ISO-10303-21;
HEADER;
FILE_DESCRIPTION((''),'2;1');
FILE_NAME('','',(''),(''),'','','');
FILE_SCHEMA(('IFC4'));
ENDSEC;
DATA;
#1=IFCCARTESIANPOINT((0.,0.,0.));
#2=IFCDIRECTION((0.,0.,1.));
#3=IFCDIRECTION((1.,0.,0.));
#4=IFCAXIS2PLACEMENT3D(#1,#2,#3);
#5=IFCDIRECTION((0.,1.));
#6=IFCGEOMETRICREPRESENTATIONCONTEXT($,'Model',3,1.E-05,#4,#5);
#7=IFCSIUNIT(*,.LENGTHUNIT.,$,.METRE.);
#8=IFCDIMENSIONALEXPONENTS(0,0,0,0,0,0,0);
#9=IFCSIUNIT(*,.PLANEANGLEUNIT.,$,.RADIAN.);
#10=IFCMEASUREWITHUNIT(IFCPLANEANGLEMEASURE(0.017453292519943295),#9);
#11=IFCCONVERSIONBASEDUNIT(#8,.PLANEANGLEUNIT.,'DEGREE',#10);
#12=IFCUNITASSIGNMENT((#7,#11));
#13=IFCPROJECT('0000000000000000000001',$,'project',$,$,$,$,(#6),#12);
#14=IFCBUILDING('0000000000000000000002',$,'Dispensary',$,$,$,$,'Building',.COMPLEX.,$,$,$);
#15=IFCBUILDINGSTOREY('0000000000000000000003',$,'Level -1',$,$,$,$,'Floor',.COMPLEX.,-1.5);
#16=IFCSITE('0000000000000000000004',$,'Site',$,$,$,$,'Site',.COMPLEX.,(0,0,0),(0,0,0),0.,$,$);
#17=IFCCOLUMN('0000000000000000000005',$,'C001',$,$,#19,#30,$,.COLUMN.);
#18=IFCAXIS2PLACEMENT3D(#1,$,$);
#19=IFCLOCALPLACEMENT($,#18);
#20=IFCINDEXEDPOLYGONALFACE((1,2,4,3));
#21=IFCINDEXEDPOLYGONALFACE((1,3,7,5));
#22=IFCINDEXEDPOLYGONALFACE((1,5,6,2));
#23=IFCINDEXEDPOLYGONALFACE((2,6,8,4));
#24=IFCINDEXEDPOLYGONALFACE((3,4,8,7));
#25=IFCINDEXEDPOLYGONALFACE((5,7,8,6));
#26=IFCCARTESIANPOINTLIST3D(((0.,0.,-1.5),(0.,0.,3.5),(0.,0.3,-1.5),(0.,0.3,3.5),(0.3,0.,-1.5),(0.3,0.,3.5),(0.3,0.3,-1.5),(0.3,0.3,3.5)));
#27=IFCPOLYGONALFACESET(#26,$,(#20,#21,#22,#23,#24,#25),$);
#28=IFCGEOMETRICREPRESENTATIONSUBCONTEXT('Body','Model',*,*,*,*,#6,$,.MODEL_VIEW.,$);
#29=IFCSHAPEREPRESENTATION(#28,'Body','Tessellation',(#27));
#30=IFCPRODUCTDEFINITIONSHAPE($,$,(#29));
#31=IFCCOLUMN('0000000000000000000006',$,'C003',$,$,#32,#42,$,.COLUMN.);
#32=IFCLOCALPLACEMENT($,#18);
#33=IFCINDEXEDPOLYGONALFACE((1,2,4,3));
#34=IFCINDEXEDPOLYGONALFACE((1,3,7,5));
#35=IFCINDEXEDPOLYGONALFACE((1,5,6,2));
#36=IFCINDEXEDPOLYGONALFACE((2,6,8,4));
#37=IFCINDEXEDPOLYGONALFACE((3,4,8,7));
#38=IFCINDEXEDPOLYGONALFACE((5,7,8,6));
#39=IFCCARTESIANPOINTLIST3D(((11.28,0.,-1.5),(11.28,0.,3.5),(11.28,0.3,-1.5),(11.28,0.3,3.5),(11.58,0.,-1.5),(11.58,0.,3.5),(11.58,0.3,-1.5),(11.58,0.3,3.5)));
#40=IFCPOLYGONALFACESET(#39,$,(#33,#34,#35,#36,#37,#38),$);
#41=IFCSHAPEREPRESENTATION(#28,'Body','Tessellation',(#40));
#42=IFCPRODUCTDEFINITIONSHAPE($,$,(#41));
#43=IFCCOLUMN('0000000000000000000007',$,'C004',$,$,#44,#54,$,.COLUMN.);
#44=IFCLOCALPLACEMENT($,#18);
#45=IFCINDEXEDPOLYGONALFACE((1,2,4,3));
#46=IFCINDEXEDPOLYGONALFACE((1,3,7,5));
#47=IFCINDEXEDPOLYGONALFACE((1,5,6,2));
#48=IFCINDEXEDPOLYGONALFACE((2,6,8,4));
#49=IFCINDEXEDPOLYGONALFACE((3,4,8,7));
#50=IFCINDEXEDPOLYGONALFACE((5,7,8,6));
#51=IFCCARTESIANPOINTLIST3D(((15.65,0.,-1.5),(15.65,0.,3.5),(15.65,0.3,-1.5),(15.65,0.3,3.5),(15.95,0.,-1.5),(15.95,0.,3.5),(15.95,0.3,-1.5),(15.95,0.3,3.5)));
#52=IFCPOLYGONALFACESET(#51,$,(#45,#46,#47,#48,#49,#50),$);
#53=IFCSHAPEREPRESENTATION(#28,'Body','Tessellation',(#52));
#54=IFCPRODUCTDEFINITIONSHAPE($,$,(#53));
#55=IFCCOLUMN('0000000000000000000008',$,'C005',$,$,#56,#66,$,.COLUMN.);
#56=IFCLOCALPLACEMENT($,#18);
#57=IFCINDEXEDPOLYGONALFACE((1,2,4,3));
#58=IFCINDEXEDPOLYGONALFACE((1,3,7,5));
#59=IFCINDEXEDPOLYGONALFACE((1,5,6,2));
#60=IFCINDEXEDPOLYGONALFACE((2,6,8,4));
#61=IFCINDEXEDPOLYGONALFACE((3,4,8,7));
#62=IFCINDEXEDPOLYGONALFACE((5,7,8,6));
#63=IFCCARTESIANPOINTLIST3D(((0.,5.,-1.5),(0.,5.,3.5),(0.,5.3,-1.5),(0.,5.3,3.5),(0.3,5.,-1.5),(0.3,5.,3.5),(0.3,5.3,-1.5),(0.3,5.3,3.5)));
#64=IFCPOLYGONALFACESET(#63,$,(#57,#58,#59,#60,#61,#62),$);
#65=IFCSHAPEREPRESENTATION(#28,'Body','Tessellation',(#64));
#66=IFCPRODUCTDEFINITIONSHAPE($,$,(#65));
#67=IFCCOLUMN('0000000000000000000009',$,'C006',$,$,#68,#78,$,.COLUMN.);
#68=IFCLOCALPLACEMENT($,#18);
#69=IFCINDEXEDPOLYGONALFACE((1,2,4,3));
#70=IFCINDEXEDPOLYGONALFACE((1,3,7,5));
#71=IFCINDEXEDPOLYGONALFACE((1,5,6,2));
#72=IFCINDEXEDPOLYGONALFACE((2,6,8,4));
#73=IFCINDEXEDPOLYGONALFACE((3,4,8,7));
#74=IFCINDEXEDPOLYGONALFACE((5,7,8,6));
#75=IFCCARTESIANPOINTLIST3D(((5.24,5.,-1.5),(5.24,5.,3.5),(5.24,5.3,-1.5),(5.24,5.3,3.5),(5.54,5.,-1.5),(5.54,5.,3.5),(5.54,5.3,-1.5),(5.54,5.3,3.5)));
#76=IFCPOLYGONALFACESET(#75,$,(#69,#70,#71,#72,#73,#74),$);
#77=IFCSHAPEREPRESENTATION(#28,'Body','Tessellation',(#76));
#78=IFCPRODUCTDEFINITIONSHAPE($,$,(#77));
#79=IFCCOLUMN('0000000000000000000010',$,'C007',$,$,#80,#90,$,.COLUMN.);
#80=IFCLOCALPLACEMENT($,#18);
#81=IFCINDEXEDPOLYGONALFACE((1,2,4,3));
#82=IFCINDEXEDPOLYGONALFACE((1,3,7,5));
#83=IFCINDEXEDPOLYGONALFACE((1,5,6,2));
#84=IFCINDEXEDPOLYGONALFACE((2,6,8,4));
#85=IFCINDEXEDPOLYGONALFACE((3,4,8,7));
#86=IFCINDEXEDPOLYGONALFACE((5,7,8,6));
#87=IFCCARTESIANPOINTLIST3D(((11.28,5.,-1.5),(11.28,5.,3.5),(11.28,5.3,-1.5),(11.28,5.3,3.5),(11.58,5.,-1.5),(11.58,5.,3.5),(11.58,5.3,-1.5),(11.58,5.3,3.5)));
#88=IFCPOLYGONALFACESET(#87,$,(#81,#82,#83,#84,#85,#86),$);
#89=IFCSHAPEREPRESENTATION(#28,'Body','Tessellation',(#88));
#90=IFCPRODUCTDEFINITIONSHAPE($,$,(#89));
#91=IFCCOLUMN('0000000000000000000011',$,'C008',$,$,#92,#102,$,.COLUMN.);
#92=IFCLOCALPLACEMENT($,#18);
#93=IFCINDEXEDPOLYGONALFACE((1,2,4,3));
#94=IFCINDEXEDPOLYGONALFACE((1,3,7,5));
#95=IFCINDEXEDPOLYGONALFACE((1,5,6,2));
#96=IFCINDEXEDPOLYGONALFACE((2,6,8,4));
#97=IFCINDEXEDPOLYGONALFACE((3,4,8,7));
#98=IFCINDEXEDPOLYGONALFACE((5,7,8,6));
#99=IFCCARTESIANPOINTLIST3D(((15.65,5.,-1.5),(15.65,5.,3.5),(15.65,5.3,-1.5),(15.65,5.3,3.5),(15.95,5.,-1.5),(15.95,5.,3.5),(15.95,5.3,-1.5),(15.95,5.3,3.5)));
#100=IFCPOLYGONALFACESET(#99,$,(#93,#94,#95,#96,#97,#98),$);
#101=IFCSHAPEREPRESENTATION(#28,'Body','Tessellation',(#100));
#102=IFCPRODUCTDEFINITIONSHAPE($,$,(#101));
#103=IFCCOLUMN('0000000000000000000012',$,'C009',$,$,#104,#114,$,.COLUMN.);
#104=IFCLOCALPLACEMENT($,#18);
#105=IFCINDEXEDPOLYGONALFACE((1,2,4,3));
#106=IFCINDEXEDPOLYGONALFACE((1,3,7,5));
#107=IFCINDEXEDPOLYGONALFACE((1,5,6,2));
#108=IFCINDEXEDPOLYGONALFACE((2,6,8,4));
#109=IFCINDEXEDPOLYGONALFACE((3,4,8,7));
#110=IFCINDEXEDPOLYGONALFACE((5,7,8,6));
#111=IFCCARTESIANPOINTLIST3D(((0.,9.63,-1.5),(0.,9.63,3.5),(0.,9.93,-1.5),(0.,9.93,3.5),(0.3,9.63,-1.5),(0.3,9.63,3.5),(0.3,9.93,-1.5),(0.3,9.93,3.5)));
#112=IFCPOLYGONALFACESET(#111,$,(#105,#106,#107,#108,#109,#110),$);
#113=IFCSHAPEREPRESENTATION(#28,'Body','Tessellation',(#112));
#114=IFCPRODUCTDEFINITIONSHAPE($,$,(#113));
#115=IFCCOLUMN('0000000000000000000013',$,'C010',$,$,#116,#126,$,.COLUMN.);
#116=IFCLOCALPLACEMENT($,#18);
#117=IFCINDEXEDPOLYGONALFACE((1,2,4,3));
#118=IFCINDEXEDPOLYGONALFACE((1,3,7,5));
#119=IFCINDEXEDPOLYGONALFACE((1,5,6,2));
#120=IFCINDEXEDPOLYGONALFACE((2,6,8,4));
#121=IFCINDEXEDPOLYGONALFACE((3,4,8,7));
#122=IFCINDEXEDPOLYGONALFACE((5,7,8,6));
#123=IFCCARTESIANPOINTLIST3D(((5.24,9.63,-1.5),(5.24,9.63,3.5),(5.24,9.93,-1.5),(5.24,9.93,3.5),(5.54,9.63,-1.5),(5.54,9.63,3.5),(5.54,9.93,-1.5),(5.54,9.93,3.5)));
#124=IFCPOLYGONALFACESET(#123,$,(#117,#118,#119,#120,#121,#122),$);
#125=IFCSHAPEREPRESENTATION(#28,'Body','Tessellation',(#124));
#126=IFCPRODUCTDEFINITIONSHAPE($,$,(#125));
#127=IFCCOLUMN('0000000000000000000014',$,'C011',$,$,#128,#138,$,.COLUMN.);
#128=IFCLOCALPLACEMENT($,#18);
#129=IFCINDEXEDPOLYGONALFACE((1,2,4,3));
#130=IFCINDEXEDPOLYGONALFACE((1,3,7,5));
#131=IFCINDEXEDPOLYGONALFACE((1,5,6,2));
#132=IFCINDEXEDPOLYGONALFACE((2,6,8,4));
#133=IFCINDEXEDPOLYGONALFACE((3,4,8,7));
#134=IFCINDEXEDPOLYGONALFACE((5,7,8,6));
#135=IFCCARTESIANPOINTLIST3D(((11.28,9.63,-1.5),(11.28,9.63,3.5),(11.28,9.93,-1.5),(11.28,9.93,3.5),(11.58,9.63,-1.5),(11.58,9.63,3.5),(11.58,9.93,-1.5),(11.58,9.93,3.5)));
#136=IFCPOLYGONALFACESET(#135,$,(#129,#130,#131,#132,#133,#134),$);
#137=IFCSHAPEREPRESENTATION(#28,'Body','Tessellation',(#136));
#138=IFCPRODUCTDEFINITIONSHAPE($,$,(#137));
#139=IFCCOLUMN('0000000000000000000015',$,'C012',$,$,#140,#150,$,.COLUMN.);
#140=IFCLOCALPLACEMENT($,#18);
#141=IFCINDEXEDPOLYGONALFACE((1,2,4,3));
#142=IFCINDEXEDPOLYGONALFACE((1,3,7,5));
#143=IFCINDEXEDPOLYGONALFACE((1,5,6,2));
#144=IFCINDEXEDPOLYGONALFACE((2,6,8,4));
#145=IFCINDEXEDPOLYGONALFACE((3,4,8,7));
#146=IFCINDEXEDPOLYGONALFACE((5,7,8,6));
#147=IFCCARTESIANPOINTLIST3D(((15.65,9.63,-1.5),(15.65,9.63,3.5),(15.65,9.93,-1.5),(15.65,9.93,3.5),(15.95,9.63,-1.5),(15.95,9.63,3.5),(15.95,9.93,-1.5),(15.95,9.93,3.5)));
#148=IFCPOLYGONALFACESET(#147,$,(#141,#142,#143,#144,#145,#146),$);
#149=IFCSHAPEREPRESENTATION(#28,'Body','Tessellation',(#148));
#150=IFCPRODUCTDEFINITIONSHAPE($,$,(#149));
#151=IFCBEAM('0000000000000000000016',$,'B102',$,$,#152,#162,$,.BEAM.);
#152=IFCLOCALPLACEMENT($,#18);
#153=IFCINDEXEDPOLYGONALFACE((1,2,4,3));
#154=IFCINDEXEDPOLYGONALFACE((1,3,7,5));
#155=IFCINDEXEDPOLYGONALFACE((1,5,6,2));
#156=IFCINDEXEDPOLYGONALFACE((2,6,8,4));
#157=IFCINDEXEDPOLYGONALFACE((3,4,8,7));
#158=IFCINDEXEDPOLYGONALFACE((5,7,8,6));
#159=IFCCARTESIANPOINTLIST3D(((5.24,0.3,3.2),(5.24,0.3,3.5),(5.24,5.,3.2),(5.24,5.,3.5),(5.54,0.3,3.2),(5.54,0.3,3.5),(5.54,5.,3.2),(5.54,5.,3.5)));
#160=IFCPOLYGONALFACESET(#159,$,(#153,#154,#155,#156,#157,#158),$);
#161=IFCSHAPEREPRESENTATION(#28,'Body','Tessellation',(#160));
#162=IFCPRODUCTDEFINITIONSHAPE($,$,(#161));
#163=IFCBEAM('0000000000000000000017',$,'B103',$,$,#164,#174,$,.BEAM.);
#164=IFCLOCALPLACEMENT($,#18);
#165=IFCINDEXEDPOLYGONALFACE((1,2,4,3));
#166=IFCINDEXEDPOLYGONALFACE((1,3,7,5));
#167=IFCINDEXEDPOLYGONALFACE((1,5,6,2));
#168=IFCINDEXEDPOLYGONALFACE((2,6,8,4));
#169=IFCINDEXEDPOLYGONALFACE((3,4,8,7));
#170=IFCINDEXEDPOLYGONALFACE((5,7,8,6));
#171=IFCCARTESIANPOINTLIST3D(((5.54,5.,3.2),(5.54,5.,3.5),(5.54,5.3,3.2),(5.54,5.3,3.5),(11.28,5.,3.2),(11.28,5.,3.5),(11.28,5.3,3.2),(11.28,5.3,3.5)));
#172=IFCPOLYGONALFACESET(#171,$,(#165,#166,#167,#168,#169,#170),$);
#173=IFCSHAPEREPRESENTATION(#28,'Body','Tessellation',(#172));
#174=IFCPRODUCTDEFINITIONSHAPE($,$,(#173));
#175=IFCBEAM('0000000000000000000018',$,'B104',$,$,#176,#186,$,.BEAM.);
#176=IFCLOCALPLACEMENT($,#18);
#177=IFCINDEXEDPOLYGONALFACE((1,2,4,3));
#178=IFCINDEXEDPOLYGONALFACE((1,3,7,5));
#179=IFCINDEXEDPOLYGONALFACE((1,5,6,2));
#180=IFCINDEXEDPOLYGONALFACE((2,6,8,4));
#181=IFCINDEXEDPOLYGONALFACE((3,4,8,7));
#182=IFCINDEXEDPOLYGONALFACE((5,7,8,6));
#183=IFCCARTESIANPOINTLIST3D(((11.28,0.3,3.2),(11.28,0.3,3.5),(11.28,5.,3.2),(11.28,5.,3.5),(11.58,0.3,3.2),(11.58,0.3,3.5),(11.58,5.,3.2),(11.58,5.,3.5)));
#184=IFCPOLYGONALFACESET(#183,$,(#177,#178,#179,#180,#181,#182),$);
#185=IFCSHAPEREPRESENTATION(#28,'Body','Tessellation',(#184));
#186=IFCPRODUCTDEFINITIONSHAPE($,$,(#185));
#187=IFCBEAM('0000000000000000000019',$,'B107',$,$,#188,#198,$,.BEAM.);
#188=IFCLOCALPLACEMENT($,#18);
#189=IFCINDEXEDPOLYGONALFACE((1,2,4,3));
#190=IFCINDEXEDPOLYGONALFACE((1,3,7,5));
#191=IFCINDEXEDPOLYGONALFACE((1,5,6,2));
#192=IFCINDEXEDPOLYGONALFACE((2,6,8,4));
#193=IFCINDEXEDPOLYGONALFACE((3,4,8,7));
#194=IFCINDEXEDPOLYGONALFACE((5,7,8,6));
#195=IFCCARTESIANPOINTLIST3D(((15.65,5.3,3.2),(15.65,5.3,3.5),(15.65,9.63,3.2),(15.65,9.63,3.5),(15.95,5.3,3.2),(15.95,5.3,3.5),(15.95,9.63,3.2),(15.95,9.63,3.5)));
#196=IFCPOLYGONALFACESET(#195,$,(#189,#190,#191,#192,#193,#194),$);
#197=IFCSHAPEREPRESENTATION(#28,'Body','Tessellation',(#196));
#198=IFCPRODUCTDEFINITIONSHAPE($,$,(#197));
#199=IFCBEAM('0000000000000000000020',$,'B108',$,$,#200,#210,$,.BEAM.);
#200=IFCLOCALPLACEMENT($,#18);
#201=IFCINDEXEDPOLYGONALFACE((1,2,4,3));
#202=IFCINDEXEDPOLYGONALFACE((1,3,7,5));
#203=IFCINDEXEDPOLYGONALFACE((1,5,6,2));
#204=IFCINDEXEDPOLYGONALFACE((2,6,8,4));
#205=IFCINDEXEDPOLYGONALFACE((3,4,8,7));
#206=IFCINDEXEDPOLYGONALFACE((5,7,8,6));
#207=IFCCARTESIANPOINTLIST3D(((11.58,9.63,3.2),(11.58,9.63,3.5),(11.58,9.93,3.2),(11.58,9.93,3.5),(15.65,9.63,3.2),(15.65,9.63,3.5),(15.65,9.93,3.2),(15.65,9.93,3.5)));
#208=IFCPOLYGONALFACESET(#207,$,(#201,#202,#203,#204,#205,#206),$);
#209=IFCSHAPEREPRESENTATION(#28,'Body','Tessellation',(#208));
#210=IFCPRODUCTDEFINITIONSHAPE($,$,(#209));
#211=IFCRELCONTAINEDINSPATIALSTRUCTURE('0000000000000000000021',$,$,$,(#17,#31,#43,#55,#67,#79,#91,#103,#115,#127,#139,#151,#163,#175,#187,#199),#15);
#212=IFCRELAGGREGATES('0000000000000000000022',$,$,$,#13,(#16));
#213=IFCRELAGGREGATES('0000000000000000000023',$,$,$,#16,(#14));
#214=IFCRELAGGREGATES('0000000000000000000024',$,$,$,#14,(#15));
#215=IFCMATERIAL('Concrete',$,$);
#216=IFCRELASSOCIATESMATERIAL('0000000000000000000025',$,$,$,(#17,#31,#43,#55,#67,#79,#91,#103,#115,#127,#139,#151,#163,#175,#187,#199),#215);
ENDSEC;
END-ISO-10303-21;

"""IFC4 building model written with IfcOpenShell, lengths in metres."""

from ifc_helpers import new_model, entity, si_unit, converted_unit, direction, frame, frame_2d, origin_with_axes, place, context, subcontext, project, spatial, rectangle, extrude, material, element, save


model = new_model("IFC4")

# Units and contexts
model_context = context("Model", 3, precision=1e-05, world=origin_with_axes(), true_north=direction((0.0, 1.0)))
body_context = subcontext(model_context, "Body", "Model", "MODEL_VIEW")
ifc_project = project(units=[si_unit("LENGTHUNIT", "METRE"), converted_unit("PLANEANGLEUNIT", "DEGREE", entity("IfcPlaneAngleMeasure", 0.017453292519943295), si_unit("PLANEANGLEUNIT", "RADIAN"), dimensions=[0, 0, 0, 0, 0, 0, 0])], contexts=[model_context])

# Site, building, storey
site = spatial("IfcSite", under=ifc_project, Name="Site", LongName="Site", CompositionType="COMPLEX", RefLatitude=(0, 0, 0), RefLongitude=(0, 0, 0), RefElevation=0.0)
building = spatial("IfcBuilding", under=site, Name="Dispensary", LongName="Building", CompositionType="COMPLEX")
storey = spatial("IfcBuildingStorey", under=building, Name="Level -1", LongName="Floor", CompositionType="COMPLEX", Elevation=-1.5)

# Columns
ifc_material = material(Name="Concrete")
placement = place(None, origin_with_axes())
element("IfcColumn", 1, at=placement, inside=storey, material=ifc_material, Name="C001", PredefinedType="COLUMN", context=body_context, shape_type="SweptSolid", body=[
    extrude(rectangle(XDim=0.3, YDim=0.3, at=frame_2d((0.0, 0.0), x_axis=(1.0, 0.0))), frame((0.15, 0.15, -1.5), z_axis=(0.0, 0.0, 1.0), x_axis=(1.0, 0.0, 0.0)), (0.0, 0.0, 1.0), 5.0),
])
element("IfcColumn", 2, at=placement, inside=storey, material=ifc_material, Name="C003", PredefinedType="COLUMN", context=body_context, shape_type="SweptSolid", body=[
    extrude(rectangle(XDim=0.3, YDim=0.3, at=frame_2d((0.0, 0.0), x_axis=(1.0, 0.0))), frame((11.43, 0.15, -1.5), z_axis=(0.0, 0.0, 1.0), x_axis=(1.0, 0.0, 0.0)), (0.0, 0.0, 1.0), 5.0),
])
element("IfcColumn", 3, at=placement, inside=storey, material=ifc_material, Name="C004", PredefinedType="COLUMN", context=body_context, shape_type="SweptSolid", body=[
    extrude(rectangle(XDim=0.3, YDim=0.3, at=frame_2d((0.0, 0.0), x_axis=(1.0, 0.0))), frame((15.8, 0.15, -1.5), z_axis=(0.0, 0.0, 1.0), x_axis=(1.0, 0.0, 0.0)), (0.0, 0.0, 1.0), 5.0),
])
element("IfcColumn", 4, at=placement, inside=storey, material=ifc_material, Name="C005", PredefinedType="COLUMN", context=body_context, shape_type="SweptSolid", body=[
    extrude(rectangle(XDim=0.3, YDim=0.3, at=frame_2d((0.0, 0.0), x_axis=(1.0, 0.0))), frame((0.15, 5.15, -1.5), z_axis=(0.0, 0.0, 1.0), x_axis=(1.0, 0.0, 0.0)), (0.0, 0.0, 1.0), 5.0),
])
element("IfcColumn", 5, at=placement, inside=storey, material=ifc_material, Name="C006", PredefinedType="COLUMN", context=body_context, shape_type="SweptSolid", body=[
    extrude(rectangle(XDim=0.3, YDim=0.3, at=frame_2d((0.0, 0.0), x_axis=(1.0, 0.0))), frame((5.39, 5.15, -1.5), z_axis=(0.0, 0.0, 1.0), x_axis=(1.0, 0.0, 0.0)), (0.0, 0.0, 1.0), 5.0),
])
element("IfcColumn", 6, at=placement, inside=storey, material=ifc_material, Name="C007", PredefinedType="COLUMN", context=body_context, shape_type="SweptSolid", body=[
    extrude(rectangle(XDim=0.3, YDim=0.3, at=frame_2d((0.0, 0.0), x_axis=(1.0, 0.0))), frame((11.43, 5.15, -1.5), z_axis=(0.0, 0.0, 1.0), x_axis=(1.0, 0.0, 0.0)), (0.0, 0.0, 1.0), 5.0),
])
element("IfcColumn", 7, at=placement, inside=storey, material=ifc_material, Name="C008", PredefinedType="COLUMN", context=body_context, shape_type="SweptSolid", body=[
    extrude(rectangle(XDim=0.3, YDim=0.3, at=frame_2d((0.0, 0.0), x_axis=(1.0, 0.0))), frame((15.8, 5.15, -1.5), z_axis=(0.0, 0.0, 1.0), x_axis=(1.0, 0.0, 0.0)), (0.0, 0.0, 1.0), 5.0),
])
element("IfcColumn", 8, at=placement, inside=storey, material=ifc_material, Name="C009", PredefinedType="COLUMN", context=body_context, shape_type="SweptSolid", body=[
    extrude(rectangle(XDim=0.3, YDim=0.3, at=frame_2d((0.0, 0.0), x_axis=(1.0, 0.0))), frame((0.15, 9.78, -1.5), z_axis=(0.0, 0.0, 1.0), x_axis=(1.0, 0.0, 0.0)), (0.0, 0.0, 1.0), 5.0),
])
element("IfcColumn", 9, at=placement, inside=storey, material=ifc_material, Name="C010", PredefinedType="COLUMN", context=body_context, shape_type="SweptSolid", body=[
    extrude(rectangle(XDim=0.3, YDim=0.3, at=frame_2d((0.0, 0.0), x_axis=(1.0, 0.0))), frame((5.39, 9.78, -1.5), z_axis=(0.0, 0.0, 1.0), x_axis=(1.0, 0.0, 0.0)), (0.0, 0.0, 1.0), 5.0),
])
element("IfcColumn", 10, at=placement, inside=storey, material=ifc_material, Name="C011", PredefinedType="COLUMN", context=body_context, shape_type="SweptSolid", body=[
    extrude(rectangle(XDim=0.3, YDim=0.3, at=frame_2d((0.0, 0.0), x_axis=(1.0, 0.0))), frame((11.43, 9.78, -1.5), z_axis=(0.0, 0.0, 1.0), x_axis=(1.0, 0.0, 0.0)), (0.0, 0.0, 1.0), 5.0),
])
element("IfcColumn", 11, at=placement, inside=storey, material=ifc_material, Name="C012", PredefinedType="COLUMN", context=body_context, shape_type="SweptSolid", body=[
    extrude(rectangle(XDim=0.3, YDim=0.3, at=frame_2d((0.0, 0.0), x_axis=(1.0, 0.0))), frame((15.8, 9.78, -1.5), z_axis=(0.0, 0.0, 1.0), x_axis=(1.0, 0.0, 0.0)), (0.0, 0.0, 1.0), 5.0),
])

# Beams
element("IfcBeam", 12, at=placement, inside=storey, material=ifc_material, Name="B102", PredefinedType="BEAM", context=body_context, shape_type="SweptSolid", body=[
    extrude(rectangle(XDim=0.3, YDim=0.3, at=frame_2d((0.0, 0.0), x_axis=(0.0, 1.0))), frame((5.39, 0.3, 3.35), z_axis=(0.0, 1.0, 0.0), x_axis=(0.0, 0.0, -1.0)), (0.0, 0.0, 1.0), 4.7),
])
element("IfcBeam", 13, at=placement, inside=storey, material=ifc_material, Name="B103", PredefinedType="BEAM", context=body_context, shape_type="SweptSolid", body=[
    extrude(rectangle(XDim=0.3, YDim=0.3, at=frame_2d((0.0, 0.0), x_axis=(0.0, 1.0))), frame((5.54, 5.15, 3.35), z_axis=(1.0, 0.0, 0.0), x_axis=(0.0, 0.0, -1.0)), (0.0, 0.0, 1.0), 5.74),
])
element("IfcBeam", 14, at=placement, inside=storey, material=ifc_material, Name="B104", PredefinedType="BEAM", context=body_context, shape_type="SweptSolid", body=[
    extrude(rectangle(XDim=0.3, YDim=0.3, at=frame_2d((0.0, 0.0), x_axis=(0.0, 1.0))), frame((11.43, 5.0, 3.35), z_axis=(0.0, -1.0, 0.0), x_axis=(0.0, 0.0, -1.0)), (0.0, 0.0, 1.0), 4.7),
])
element("IfcBeam", 15, at=placement, inside=storey, material=ifc_material, Name="B107", PredefinedType="BEAM", context=body_context, shape_type="SweptSolid", body=[
    extrude(rectangle(XDim=0.3, YDim=0.3, at=frame_2d((0.0, 0.0), x_axis=(0.0, 1.0))), frame((15.8, 5.3, 3.35), z_axis=(0.0, 1.0, 0.0), x_axis=(0.0, 0.0, -1.0)), (0.0, 0.0, 1.0), 4.33),
])
element("IfcBeam", 16, at=placement, inside=storey, material=ifc_material, Name="B108", PredefinedType="BEAM", context=body_context, shape_type="SweptSolid", body=[
    extrude(rectangle(XDim=0.3, YDim=0.3, at=frame_2d((0.0, 0.0), x_axis=(0.0, 1.0))), frame((15.65, 9.78, 3.35), z_axis=(-1.0, 0.0, 0.0), x_axis=(0.0, 0.0, -1.0)), (0.0, 0.0, 1.0), 4.07),
])

save(model, "model.ifc")
